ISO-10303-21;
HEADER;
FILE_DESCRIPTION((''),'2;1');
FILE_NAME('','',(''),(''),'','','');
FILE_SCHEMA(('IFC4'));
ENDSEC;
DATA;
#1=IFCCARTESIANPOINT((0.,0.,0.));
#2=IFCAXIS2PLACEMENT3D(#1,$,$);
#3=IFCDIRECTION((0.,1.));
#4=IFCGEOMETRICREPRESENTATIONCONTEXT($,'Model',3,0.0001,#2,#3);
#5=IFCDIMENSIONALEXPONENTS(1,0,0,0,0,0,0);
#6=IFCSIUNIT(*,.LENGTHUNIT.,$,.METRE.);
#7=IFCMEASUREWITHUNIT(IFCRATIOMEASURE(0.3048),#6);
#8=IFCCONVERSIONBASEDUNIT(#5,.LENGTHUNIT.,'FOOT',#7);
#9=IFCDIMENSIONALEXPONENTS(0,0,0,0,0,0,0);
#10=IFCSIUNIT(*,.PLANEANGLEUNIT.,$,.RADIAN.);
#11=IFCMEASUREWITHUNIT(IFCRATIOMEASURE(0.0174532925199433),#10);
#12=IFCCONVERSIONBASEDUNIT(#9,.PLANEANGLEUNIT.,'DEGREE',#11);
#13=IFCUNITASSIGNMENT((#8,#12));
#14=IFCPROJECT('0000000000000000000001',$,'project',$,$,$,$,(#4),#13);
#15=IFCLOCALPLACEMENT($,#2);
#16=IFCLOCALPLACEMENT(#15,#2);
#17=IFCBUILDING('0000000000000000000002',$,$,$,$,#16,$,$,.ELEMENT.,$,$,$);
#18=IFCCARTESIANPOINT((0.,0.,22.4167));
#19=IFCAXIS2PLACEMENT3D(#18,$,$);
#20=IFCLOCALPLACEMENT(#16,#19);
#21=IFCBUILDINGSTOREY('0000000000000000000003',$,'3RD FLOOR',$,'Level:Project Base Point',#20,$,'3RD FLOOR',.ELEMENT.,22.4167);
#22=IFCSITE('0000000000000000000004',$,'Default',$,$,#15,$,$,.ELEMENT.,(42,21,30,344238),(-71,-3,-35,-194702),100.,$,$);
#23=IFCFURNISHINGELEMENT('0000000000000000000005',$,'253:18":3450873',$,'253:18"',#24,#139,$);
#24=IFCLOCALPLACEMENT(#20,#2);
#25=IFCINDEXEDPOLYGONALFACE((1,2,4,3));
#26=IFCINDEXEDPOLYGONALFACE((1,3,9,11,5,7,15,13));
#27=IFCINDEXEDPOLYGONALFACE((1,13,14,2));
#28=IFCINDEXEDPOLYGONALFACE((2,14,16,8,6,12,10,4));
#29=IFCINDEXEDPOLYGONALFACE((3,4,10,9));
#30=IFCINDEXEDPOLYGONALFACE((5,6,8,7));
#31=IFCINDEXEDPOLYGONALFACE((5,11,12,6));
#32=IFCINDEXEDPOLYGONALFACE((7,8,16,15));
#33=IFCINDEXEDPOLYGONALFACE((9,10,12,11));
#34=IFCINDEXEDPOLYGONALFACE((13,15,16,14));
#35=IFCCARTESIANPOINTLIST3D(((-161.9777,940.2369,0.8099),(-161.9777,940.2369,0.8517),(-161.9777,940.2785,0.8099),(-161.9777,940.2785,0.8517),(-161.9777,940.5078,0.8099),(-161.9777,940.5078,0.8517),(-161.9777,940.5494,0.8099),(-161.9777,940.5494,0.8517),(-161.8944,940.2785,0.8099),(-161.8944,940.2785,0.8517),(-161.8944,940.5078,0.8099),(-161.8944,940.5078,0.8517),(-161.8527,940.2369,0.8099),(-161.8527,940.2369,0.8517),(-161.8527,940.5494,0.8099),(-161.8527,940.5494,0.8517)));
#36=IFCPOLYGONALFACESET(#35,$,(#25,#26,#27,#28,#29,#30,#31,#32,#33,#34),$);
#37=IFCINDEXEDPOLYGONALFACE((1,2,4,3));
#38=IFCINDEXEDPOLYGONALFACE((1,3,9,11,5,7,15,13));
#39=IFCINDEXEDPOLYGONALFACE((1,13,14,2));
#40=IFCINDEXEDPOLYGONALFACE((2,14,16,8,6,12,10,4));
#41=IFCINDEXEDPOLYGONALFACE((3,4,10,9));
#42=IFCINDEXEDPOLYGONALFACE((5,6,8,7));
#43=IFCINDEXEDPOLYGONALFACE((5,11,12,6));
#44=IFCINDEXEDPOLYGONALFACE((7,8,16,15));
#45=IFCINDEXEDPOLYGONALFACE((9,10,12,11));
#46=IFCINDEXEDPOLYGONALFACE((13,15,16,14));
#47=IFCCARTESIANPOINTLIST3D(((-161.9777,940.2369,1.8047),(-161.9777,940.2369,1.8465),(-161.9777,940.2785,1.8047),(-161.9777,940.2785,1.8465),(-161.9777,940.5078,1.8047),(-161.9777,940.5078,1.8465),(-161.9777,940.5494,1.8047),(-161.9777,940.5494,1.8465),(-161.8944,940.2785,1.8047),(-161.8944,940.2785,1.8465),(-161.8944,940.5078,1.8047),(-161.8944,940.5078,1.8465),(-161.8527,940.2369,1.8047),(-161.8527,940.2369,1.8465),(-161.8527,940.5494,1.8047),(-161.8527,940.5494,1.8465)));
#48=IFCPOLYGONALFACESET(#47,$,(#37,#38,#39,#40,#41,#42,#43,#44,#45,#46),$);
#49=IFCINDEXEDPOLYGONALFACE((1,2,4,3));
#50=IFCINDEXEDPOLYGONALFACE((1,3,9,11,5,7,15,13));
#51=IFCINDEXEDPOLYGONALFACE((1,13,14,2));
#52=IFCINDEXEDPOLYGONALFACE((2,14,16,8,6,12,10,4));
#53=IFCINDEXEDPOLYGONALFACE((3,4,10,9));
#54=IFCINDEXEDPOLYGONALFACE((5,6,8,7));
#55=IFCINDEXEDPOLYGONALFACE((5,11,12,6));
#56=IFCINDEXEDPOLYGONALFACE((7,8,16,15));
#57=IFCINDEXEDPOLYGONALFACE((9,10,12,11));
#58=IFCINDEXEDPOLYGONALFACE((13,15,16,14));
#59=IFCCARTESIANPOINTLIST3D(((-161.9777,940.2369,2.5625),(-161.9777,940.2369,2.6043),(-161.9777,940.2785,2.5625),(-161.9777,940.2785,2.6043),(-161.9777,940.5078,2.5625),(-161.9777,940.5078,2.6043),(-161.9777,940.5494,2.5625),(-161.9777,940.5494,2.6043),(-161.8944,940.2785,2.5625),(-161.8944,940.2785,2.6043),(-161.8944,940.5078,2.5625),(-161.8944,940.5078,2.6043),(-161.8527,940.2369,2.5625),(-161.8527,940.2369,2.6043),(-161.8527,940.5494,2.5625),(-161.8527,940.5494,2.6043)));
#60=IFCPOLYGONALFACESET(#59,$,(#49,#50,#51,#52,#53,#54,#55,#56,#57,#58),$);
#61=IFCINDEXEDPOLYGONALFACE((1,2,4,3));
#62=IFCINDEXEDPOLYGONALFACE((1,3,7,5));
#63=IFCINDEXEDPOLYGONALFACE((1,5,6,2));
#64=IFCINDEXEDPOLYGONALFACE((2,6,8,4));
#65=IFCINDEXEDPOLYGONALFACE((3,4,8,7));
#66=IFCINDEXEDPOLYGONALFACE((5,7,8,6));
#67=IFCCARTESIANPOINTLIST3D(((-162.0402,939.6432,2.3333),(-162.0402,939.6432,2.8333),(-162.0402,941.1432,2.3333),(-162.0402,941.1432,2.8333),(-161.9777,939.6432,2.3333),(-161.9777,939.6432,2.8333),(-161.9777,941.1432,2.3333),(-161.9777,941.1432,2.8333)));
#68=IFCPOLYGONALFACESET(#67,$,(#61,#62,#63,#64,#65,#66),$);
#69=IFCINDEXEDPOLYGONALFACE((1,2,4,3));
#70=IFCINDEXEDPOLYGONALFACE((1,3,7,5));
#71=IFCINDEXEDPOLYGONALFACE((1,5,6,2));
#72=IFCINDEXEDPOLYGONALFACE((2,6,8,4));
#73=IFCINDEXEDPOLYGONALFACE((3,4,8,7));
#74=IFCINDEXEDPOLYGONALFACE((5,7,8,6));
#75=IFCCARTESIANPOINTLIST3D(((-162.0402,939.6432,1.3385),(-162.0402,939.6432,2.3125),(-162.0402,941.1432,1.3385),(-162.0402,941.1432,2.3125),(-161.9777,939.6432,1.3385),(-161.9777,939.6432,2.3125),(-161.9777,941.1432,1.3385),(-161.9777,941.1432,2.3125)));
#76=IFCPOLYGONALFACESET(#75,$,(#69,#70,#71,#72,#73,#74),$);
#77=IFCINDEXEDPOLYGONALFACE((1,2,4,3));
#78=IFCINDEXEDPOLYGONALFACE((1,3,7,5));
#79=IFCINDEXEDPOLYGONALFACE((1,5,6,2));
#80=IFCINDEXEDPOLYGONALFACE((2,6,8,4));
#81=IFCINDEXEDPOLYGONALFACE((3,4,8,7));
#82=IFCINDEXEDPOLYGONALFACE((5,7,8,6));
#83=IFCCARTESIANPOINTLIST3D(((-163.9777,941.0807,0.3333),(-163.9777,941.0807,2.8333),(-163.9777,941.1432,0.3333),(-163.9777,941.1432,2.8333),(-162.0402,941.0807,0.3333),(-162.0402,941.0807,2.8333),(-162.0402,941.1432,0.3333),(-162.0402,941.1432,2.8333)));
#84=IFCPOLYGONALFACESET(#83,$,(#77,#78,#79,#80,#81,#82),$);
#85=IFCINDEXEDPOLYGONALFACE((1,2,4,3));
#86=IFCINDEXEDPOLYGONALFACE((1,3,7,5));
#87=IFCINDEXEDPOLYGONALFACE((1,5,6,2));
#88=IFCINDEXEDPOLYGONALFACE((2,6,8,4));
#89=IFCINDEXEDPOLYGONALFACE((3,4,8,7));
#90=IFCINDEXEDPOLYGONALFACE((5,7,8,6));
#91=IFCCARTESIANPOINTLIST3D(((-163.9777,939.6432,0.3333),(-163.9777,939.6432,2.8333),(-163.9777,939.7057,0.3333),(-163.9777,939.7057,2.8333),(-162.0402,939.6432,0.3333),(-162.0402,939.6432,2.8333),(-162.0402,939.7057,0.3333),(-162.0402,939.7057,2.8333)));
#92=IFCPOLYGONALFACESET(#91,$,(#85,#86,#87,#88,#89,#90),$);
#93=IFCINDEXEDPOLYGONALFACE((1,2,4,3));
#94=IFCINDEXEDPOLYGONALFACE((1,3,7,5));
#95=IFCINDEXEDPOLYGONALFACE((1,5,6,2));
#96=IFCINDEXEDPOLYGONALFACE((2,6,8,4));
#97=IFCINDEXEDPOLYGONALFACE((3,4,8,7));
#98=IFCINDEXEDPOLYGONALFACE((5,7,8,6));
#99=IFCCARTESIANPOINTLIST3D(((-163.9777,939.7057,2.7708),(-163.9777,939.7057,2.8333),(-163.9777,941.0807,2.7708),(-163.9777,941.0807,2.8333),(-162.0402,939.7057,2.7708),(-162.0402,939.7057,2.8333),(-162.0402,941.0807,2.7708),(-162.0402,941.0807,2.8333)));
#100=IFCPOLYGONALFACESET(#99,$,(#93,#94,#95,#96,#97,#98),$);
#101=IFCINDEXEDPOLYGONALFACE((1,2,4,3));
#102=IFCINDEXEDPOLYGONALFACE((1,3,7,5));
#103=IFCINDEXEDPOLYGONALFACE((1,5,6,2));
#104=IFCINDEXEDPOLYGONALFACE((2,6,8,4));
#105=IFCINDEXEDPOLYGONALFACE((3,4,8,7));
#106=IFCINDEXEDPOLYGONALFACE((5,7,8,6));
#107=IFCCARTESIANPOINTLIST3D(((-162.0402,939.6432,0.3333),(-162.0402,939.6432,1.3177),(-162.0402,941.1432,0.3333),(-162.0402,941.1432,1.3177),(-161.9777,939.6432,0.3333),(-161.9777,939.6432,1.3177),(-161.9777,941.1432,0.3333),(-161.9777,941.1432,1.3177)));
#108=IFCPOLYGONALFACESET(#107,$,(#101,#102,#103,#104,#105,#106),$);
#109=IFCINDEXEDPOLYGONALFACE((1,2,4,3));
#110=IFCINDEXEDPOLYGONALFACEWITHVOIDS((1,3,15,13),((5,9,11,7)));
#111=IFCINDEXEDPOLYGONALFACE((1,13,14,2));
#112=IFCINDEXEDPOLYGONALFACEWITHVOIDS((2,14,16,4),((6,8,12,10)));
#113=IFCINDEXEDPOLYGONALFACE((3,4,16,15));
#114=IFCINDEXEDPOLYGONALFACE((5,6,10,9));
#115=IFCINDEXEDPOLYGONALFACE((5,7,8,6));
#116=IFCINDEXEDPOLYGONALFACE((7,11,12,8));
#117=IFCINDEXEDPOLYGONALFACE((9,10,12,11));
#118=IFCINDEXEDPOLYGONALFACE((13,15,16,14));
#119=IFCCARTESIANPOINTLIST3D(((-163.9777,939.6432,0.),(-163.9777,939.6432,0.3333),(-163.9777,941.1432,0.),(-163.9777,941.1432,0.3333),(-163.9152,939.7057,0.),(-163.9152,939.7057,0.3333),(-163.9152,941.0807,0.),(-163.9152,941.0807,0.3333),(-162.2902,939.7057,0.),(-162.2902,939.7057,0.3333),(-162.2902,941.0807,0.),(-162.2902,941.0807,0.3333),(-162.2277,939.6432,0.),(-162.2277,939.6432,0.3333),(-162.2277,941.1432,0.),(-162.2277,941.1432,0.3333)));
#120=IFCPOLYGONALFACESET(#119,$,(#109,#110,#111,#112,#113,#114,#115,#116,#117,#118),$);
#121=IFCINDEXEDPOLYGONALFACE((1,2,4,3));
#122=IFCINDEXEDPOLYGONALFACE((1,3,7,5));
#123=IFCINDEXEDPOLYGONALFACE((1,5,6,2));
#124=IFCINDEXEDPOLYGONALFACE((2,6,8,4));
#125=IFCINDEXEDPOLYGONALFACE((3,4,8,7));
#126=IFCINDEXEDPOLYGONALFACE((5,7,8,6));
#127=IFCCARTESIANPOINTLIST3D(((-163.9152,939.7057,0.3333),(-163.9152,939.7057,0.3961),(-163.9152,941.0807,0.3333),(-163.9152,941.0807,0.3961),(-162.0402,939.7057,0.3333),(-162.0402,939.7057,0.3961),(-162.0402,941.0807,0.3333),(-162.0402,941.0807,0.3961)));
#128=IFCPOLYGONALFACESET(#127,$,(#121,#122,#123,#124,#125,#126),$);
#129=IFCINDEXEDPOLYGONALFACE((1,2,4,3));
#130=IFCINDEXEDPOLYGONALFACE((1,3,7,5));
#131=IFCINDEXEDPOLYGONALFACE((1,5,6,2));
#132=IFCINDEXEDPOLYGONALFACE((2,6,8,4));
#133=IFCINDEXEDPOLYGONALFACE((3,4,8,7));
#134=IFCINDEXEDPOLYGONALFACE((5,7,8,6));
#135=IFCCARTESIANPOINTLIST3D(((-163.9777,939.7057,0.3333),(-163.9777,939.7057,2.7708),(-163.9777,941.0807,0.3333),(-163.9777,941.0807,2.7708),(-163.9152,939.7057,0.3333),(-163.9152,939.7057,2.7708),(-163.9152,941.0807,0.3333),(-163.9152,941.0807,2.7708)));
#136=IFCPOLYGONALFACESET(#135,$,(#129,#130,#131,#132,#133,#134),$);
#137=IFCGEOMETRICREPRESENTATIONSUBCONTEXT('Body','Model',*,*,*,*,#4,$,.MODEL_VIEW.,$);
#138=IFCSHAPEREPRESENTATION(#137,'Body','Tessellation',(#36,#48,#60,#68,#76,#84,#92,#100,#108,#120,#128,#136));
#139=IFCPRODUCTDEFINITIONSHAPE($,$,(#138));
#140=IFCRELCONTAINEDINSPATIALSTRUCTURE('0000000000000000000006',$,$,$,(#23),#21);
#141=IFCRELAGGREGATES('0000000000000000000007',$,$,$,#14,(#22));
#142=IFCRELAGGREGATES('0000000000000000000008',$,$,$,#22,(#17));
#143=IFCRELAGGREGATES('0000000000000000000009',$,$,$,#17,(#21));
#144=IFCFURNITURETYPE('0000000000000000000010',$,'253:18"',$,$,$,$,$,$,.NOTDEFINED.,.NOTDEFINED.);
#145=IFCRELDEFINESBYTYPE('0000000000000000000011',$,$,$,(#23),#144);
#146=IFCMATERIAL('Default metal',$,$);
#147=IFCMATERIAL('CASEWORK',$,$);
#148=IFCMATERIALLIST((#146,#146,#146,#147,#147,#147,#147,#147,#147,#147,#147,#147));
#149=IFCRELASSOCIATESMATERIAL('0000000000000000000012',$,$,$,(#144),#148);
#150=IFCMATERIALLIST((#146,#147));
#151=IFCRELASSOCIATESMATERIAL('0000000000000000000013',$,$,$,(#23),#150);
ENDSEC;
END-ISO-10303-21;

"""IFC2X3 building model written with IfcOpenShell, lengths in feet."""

from ifc_helpers import new_model, entity, si_unit, converted_unit, direction, frame, frame_2d, origin, origin_2d_with_axis, place, context, subcontext, project, spatial, polyline, rectangle, outline, extrude, source, transform, mapped, material, material_list, type_object, type_shapes, element, save


model = new_model("IFC2X3")

# Units and contexts
model_context = context("Model", 3, precision=0.0001, world=origin(), true_north=direction((0.0, 1.0)))
body_context = subcontext(model_context, "Body", "Model", "MODEL_VIEW")
ifc_project = project(units=[converted_unit("LENGTHUNIT", "FOOT", entity("IfcRatioMeasure", 0.3048), si_unit("LENGTHUNIT", "METRE"), dimensions=[1, 0, 0, 0, 0, 0, 0]), converted_unit("PLANEANGLEUNIT", "DEGREE", entity("IfcRatioMeasure", 0.0174532925199433), si_unit("PLANEANGLEUNIT", "RADIAN"), dimensions=[0, 0, 0, 0, 0, 0, 0])], contexts=[model_context])

# Site, building, storey
site_placement = place(None, origin())
site = spatial("IfcSite", under=ifc_project, at=site_placement, Name="Default", CompositionType="ELEMENT", RefLatitude=(42, 21, 30, 344238), RefLongitude=(-71, -3, -35, -194702), RefElevation=100.0)
building_placement = place(site_placement, origin())
building = spatial("IfcBuilding", under=site, at=building_placement, CompositionType="ELEMENT")
storey_placement = place(building_placement, frame((0.0, 0.0, 22.4167)))
storey = spatial("IfcBuildingStorey", under=building, at=storey_placement, Name="3RD FLOOR", ObjectType="Level:Project Base Point", LongName="3RD FLOOR", CompositionType="ELEMENT", Elevation=22.4167)

# Furnishing element
ifc_material_1 = material(Name="CASEWORK")
ifc_material_2 = material(Name="Default metal")
ifc_material_list_1 = material_list([ifc_material_2, ifc_material_1])
ifc_material_list_2 = material_list([ifc_material_2, ifc_material_2, ifc_material_2, ifc_material_1, ifc_material_1, ifc_material_1, ifc_material_1, ifc_material_1, ifc_material_1, ifc_material_1, ifc_material_1, ifc_material_1])
furniture_type_1 = type_object("IfcFurnitureType", Name="253:18\"", material=ifc_material_list_2)
shared_shape_1 = source(origin(), body_context, "Body", "SweptSolid", [
    extrude(outline(polyline([(-0.1562, -0.0521), (-0.1146, -0.0521), (-0.1146, 0.0313), (0.1146, 0.0313), (0.1146, -0.0521), (0.1562, -0.0521), (0.1562, 0.0729), (-0.1562, 0.0729), (-0.1562, -0.0521)])), frame((0.0615, 2.0521, 0.8099)), (0.0, 0.0, 1.0), 0.0418),
    extrude(outline(polyline([(-0.1562, -0.0521), (-0.1146, -0.0521), (-0.1146, 0.0313), (0.1146, 0.0313), (0.1146, -0.0521), (0.1562, -0.0521), (0.1562, 0.0729), (-0.1562, 0.0729), (-0.1562, -0.0521)])), frame((0.0615, 2.0521, 1.8047)), (0.0, 0.0, 1.0), 0.0418),
    extrude(outline(polyline([(-0.1562, -0.0521), (-0.1146, -0.0521), (-0.1146, 0.0313), (0.1146, 0.0313), (0.1146, -0.0521), (0.1562, -0.0521), (0.1562, 0.0729), (-0.1562, 0.0729), (-0.1562, -0.0521)])), frame((0.0615, 2.0521, 2.5625)), (0.0, 0.0, 1.0), 0.0418),
    extrude(rectangle(XDim=1.5, YDim=0.0625, at=frame_2d((0.0, 0.0), x_axis=(1.0, 0.0))), frame((0.0615, 1.9688, 2.3333), z_axis=(0.0, 0.0, 1.0), x_axis=(-1.0, 0.0, 0.0)), (0.0, 0.0, 1.0), 0.5),
    extrude(rectangle(XDim=1.5, YDim=0.0625, at=frame_2d((0.0, 0.0), x_axis=(1.0, 0.0))), frame((0.0615, 1.9688, 1.3385), z_axis=(0.0, 0.0, 1.0), x_axis=(-1.0, 0.0, 0.0)), (0.0, 0.0, 1.0), 0.974),
    extrude(rectangle(XDim=1.9375, YDim=0.0625, at=frame_2d((0.0, 0.0), x_axis=(1.0, 0.0))), frame((-0.6573, 0.9687, 0.3333), z_axis=(0.0, 0.0, 1.0), x_axis=(0.0, -1.0, 0.0)), (0.0, 0.0, 1.0), 2.5),
    extrude(rectangle(XDim=1.9375, YDim=0.0625, at=frame_2d((0.0, 0.0), x_axis=(1.0, 0.0))), frame((0.7802, 0.9687, 0.3333), z_axis=(0.0, 0.0, 1.0), x_axis=(0.0, -1.0, 0.0)), (0.0, 0.0, 1.0), 2.5),
    extrude(rectangle(XDim=1.9375, YDim=1.375, at=origin_2d_with_axis()), frame((0.0615, 0.9688, 2.7708), z_axis=(0.0, 0.0, 1.0), x_axis=(0.0, 1.0, 0.0)), (0.0, 0.0, 1.0), 0.0625),
    extrude(rectangle(XDim=1.5, YDim=0.0625, at=frame_2d((0.0, 0.0), x_axis=(1.0, 0.0))), frame((0.0615, 1.9688, 0.3333), z_axis=(0.0, 0.0, 1.0), x_axis=(-1.0, 0.0, 0.0)), (0.0, 0.0, 1.0), 0.9844),
    extrude(outline(polyline([(-0.875, -0.75), (0.875, -0.75), (0.875, 0.75), (-0.875, 0.75), (-0.875, -0.75)]), holes=[polyline([(-0.8125, -0.6875), (-0.8125, 0.6875), (0.8125, 0.6875), (0.8125, -0.6875), (-0.8125, -0.6875)])]), frame((0.0615, 0.875, 0.0), z_axis=(0.0, 0.0, 1.0), x_axis=(0.0, -1.0, 0.0)), (0.0, 0.0, 1.0), 0.3333),
    extrude(rectangle(XDim=1.875, YDim=1.375, at=origin_2d_with_axis()), frame((0.0615, 1.0, 0.3333), z_axis=(0.0, 0.0, 1.0), x_axis=(0.0, 1.0, 0.0)), (0.0, 0.0, 1.0), 0.0627),
    extrude(rectangle(XDim=1.375, YDim=0.0625, at=origin_2d_with_axis()), frame((0.0615, 0.0312, 0.3333), z_axis=(0.0, 0.0, 1.0), x_axis=(-1.0, 0.0, 0.0)), (0.0, 0.0, 1.0), 2.4375),
])
type_shapes(furniture_type_1, [shared_shape_1])
furnishing_1_placement = place(storey_placement, frame((-163.9777, 940.4547, 0.0), z_axis=(0.0, 0.0, 1.0), x_axis=(0.0, -1.0, 0.0)))
element("IfcFurnishingElement", 1, at=furnishing_1_placement, inside=storey, type_object=furniture_type_1, material=ifc_material_list_1, Name="253:18\":3450873", ObjectType="253:18\"", context=body_context, shape_type="MappedRepresentation", body=[
    mapped(shared_shape_1, transform((0.0, 0.0, 0.0), scale=1.0)),
])

save(model, "model.ifc")
